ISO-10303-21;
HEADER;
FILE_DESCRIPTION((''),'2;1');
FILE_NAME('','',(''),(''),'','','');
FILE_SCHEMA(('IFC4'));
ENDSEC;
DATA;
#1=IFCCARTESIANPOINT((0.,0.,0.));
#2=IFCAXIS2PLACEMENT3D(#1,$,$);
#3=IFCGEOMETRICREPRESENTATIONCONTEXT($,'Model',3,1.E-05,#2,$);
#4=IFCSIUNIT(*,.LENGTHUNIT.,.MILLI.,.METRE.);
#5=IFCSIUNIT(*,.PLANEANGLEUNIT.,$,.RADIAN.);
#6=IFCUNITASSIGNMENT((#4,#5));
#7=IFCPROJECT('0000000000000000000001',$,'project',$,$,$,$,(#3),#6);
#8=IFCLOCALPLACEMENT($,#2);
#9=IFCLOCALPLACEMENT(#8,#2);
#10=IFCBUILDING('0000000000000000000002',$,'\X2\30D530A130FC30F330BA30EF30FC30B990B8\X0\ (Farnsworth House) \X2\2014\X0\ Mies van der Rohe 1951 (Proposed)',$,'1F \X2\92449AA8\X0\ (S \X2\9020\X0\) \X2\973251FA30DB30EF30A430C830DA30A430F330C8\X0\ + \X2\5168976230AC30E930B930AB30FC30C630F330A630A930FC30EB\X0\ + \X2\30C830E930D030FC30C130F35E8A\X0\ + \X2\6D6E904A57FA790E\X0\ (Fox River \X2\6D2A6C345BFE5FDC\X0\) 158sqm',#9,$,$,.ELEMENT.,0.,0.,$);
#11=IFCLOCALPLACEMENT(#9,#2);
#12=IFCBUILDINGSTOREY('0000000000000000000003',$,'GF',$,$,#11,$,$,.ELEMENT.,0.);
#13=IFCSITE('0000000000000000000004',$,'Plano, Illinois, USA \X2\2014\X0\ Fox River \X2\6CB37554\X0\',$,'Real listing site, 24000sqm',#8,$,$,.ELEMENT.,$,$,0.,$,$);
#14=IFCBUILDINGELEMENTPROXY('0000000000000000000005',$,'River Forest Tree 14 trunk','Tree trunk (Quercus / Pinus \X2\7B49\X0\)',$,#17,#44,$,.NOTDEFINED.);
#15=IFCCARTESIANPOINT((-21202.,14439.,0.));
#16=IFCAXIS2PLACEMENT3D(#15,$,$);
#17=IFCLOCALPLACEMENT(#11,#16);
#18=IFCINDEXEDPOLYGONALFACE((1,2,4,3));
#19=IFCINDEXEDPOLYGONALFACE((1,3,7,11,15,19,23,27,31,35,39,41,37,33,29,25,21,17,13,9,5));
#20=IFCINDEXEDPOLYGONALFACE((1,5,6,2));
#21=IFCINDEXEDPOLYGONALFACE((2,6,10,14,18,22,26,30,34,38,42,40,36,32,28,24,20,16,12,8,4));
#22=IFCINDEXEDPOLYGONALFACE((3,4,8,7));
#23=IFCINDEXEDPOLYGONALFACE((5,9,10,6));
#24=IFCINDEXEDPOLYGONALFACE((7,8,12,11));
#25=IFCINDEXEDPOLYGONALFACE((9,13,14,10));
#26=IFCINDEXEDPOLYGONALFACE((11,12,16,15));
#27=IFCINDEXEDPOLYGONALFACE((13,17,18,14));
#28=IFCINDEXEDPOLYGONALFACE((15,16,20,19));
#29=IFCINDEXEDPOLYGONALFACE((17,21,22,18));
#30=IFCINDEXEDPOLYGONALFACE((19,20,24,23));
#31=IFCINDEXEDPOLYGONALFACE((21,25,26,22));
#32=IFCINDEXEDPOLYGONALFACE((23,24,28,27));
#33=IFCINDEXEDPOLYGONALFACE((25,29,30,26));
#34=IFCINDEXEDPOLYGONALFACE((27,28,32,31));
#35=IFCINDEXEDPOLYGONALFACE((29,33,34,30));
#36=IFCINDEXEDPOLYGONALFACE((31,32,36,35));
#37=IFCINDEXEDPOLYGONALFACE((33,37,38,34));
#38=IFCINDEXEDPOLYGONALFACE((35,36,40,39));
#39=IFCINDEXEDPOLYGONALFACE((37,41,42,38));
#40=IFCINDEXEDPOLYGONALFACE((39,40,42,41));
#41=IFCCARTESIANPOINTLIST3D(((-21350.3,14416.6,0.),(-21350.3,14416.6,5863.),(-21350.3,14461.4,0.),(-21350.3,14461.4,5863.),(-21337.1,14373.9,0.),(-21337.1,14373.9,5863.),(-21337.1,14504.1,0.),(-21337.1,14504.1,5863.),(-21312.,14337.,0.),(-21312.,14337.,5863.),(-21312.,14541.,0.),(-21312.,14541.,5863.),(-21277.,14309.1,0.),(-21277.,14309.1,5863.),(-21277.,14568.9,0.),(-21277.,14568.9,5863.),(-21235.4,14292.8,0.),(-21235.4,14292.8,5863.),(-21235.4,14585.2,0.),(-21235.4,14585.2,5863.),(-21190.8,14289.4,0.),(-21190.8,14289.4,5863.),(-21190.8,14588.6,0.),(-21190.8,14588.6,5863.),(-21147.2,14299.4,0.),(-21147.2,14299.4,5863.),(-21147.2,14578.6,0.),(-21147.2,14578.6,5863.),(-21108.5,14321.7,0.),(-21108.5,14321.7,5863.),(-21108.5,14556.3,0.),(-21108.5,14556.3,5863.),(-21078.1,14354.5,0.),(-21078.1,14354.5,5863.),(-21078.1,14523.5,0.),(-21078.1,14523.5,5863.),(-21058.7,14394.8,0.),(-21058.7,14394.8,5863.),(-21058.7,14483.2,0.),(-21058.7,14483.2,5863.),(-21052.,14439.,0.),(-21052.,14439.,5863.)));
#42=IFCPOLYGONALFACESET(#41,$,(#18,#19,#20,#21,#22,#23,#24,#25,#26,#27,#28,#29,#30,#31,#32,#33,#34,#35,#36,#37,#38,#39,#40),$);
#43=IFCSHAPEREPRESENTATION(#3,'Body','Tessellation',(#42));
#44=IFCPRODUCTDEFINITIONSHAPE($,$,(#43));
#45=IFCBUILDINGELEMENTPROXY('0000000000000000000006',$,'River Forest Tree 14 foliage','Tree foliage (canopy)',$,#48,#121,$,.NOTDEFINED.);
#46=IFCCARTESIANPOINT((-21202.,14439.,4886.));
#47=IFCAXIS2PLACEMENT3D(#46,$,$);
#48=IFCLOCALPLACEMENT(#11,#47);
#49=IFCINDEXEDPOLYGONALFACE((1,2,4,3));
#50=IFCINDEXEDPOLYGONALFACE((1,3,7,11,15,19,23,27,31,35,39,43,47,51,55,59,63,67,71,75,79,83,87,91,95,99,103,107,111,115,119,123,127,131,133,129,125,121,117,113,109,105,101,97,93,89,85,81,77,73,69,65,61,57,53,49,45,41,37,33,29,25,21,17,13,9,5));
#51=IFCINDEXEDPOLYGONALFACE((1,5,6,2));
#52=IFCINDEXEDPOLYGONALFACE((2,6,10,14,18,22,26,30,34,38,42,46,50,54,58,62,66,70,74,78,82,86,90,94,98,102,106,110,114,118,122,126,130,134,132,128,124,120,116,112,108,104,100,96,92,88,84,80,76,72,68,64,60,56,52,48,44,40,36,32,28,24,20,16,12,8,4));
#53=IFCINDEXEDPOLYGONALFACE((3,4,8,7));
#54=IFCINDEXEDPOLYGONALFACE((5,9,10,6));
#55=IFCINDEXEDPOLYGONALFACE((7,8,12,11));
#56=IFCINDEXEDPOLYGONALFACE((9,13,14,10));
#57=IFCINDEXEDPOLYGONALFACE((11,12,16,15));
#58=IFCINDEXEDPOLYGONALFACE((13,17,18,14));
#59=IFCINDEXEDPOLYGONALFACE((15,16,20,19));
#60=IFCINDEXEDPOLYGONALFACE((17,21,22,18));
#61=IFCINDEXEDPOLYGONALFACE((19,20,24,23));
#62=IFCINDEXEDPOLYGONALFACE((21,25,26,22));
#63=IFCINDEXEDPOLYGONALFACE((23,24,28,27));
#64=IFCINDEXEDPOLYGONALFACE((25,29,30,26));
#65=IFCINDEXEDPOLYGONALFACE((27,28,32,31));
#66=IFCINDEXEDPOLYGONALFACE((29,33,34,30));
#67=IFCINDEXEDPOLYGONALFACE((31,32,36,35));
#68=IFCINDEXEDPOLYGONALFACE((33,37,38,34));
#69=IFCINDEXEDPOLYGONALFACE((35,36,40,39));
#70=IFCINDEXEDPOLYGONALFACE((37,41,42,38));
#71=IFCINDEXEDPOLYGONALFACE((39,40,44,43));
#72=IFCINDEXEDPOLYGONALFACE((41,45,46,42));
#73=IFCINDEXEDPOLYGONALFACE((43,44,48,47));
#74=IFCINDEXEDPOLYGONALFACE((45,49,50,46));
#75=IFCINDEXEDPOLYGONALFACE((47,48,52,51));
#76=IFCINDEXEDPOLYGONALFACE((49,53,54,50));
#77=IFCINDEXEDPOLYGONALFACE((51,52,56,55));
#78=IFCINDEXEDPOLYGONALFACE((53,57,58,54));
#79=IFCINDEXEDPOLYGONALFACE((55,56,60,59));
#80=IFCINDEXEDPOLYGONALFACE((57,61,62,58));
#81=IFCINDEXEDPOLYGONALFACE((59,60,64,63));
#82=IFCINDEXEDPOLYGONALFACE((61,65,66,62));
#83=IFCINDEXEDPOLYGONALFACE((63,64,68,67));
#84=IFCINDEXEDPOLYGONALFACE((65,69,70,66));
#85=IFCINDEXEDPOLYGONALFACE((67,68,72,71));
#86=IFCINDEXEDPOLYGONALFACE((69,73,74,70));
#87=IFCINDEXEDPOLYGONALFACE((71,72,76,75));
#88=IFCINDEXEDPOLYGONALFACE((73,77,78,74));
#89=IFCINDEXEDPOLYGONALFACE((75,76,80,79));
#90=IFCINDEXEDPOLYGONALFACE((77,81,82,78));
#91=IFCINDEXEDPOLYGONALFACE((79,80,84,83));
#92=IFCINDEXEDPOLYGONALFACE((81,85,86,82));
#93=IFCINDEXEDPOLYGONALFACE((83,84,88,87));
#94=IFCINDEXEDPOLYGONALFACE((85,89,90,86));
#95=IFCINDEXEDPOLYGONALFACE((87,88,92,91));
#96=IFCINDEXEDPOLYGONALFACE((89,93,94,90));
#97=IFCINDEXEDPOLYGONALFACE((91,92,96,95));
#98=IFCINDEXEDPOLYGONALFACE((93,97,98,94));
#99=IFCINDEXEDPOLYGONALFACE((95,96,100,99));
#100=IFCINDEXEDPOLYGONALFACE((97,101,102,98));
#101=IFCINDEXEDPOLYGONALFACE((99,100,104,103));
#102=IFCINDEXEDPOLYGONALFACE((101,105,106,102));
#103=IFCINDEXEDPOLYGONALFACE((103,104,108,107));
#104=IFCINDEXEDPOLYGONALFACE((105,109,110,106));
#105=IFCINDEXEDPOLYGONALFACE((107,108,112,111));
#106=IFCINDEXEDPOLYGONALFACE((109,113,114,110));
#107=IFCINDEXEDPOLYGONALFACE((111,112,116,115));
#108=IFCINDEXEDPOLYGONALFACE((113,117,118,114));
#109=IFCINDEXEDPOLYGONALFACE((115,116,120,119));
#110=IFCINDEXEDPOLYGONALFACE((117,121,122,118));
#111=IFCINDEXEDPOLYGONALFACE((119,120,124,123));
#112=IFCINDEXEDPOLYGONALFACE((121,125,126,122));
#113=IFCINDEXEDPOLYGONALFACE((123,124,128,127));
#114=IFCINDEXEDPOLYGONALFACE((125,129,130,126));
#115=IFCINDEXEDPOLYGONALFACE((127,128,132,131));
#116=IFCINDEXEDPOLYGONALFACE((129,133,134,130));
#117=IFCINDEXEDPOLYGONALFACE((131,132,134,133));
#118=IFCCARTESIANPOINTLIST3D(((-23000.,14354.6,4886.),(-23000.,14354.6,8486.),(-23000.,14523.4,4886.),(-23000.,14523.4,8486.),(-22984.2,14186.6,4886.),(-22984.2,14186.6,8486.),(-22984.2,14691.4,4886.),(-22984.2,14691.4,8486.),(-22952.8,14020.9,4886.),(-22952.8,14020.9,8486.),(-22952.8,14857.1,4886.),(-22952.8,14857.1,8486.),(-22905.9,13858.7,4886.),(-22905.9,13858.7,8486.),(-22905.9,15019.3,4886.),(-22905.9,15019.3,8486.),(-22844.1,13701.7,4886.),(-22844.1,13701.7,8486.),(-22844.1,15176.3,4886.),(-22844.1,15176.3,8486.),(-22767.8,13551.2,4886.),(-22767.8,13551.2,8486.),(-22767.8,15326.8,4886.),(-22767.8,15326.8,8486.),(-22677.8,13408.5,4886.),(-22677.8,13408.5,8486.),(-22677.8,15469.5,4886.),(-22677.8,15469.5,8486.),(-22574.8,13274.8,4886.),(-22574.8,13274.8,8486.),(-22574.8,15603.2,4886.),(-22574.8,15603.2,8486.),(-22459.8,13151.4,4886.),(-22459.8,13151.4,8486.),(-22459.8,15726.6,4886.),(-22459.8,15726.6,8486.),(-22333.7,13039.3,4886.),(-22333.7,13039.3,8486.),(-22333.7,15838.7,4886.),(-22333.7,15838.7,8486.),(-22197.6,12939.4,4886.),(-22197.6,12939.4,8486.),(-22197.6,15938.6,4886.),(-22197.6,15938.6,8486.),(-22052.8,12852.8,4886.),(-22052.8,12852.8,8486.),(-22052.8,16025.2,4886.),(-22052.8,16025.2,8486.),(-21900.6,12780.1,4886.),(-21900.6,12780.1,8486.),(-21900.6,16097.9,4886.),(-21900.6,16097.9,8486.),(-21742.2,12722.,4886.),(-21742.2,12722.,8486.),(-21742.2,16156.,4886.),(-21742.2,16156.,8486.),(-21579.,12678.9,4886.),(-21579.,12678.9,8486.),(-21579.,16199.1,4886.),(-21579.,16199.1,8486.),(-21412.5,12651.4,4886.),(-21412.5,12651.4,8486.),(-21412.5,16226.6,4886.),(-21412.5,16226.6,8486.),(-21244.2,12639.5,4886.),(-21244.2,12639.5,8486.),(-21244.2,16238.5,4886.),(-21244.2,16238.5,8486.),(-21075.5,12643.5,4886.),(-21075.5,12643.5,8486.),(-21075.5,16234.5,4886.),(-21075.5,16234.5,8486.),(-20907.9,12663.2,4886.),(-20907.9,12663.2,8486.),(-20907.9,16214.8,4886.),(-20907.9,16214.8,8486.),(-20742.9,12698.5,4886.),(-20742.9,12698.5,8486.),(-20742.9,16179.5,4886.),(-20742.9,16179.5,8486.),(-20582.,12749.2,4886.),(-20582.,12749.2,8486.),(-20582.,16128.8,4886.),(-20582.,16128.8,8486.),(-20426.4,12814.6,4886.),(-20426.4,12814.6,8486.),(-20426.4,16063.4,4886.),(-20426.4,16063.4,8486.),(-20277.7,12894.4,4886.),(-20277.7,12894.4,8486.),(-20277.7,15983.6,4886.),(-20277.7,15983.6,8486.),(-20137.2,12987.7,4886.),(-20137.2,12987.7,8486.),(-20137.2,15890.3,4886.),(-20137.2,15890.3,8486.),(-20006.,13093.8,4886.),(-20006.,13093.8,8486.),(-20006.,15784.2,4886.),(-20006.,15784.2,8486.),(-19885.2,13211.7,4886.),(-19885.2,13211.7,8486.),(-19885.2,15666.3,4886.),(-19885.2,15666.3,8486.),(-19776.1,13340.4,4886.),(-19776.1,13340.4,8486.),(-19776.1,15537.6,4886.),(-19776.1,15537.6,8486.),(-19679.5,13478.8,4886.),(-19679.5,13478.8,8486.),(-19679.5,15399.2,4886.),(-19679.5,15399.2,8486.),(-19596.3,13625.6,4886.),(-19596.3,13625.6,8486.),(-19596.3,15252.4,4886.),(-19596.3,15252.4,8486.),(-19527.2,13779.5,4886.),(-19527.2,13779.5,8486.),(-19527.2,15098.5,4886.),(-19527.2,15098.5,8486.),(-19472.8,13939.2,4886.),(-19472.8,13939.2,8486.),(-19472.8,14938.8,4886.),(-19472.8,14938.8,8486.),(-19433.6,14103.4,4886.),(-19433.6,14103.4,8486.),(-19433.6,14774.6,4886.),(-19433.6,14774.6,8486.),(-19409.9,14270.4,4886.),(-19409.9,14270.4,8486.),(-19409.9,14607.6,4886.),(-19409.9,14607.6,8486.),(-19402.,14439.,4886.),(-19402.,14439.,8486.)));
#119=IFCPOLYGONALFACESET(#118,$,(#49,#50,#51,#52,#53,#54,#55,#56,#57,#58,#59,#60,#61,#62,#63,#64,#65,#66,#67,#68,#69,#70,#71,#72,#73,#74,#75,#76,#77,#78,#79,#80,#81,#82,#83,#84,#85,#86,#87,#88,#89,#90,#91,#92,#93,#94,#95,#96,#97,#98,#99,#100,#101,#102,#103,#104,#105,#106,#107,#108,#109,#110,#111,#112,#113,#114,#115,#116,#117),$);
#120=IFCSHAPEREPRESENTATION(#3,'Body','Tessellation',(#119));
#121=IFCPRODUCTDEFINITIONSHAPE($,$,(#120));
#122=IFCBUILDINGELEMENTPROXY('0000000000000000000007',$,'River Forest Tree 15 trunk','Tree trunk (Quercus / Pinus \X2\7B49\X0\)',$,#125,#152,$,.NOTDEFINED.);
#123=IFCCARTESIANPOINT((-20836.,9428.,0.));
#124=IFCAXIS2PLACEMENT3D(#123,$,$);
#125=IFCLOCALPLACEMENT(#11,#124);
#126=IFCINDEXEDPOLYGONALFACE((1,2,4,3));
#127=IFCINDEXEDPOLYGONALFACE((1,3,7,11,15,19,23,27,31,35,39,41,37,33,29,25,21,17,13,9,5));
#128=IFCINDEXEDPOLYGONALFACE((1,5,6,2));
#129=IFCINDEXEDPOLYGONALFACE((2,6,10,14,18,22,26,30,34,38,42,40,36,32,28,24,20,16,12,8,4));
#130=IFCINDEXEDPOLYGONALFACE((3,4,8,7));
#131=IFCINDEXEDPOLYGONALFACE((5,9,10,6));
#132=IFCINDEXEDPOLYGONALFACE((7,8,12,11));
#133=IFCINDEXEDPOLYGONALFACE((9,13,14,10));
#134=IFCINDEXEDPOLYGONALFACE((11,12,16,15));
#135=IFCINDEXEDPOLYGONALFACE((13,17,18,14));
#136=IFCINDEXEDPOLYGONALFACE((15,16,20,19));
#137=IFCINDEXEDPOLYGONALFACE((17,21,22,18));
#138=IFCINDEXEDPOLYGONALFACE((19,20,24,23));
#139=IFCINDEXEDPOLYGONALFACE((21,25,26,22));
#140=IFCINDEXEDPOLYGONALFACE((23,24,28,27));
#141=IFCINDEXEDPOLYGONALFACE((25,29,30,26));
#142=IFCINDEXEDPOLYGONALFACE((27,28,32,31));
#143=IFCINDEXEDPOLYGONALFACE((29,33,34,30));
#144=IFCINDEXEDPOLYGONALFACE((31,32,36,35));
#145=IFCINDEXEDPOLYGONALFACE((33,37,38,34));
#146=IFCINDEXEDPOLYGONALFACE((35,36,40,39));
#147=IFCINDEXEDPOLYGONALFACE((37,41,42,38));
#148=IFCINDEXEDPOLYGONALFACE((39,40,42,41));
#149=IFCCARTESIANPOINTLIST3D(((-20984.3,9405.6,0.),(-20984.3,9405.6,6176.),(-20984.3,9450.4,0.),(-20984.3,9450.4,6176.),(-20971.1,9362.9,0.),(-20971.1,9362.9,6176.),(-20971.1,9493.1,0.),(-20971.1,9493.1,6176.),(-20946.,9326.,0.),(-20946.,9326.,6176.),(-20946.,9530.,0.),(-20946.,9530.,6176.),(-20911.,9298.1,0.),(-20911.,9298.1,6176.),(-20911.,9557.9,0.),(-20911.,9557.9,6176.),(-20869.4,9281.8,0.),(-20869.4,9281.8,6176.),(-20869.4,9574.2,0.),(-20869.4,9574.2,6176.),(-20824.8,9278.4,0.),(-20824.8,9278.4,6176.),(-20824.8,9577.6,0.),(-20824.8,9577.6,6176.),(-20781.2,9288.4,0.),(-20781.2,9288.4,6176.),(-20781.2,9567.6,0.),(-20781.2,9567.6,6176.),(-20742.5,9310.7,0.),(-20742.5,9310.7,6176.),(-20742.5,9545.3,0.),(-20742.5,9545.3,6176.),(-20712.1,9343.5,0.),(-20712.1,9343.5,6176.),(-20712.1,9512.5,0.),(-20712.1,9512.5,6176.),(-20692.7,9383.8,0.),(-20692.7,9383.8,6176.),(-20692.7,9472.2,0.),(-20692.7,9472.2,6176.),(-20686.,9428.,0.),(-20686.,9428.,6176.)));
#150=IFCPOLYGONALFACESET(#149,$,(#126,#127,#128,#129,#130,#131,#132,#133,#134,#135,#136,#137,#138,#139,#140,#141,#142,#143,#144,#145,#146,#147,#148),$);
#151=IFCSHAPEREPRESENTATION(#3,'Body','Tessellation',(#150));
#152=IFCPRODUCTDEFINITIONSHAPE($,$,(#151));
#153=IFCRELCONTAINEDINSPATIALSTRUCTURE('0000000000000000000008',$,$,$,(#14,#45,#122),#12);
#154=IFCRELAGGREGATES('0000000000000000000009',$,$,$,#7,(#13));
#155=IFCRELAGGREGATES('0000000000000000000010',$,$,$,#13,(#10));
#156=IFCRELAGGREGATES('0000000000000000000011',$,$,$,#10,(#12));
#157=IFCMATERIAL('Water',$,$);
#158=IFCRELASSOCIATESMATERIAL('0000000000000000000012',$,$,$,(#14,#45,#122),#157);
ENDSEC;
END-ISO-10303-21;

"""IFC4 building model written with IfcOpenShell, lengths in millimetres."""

from ifc_helpers import new_model, si_unit, frame, origin, origin_2d, place, context, project, spatial, circle, extrude, material, element, save


model = new_model("IFC4")

# Units and contexts
model_context = context("Model", 3, precision=1e-05, world=origin())
ifc_project = project(units=[si_unit("LENGTHUNIT", "METRE", prefix="MILLI"), si_unit("PLANEANGLEUNIT", "RADIAN")], contexts=[model_context])

# Site, building, storey
site_placement = place(None, origin())
site = spatial("IfcSite", under=ifc_project, at=site_placement, Name="Plano, Illinois, USA — Fox River 河畔", ObjectType="Real listing site, 24000sqm", CompositionType="ELEMENT", RefElevation=0.0)
building_placement = place(site_placement, origin())
building = spatial("IfcBuilding", under=site, at=building_placement, Name="ファーンズワース邸 (Farnsworth House) — Mies van der Rohe 1951 (Proposed)", ObjectType="1F 鉄骨 (S 造) 露出ホワイトペイント + 全面ガラスカーテンウォール + トラバーチン床 + 浮遊基礎 (Fox River 洪水対応) 158sqm", CompositionType="ELEMENT", ElevationOfRefHeight=0.0, ElevationOfTerrain=0.0)
storey_placement = place(building_placement, origin())
storey = spatial("IfcBuildingStorey", under=building, at=storey_placement, Name="GF", CompositionType="ELEMENT", Elevation=0.0)

# Building element proxies
ifc_material_1 = material(Name="Water")
proxy_1_placement = place(storey_placement, frame((-21202.0, 14439.0, 0.0)))
element("IfcBuildingElementProxy", 1, at=proxy_1_placement, inside=storey, material=ifc_material_1, Name="River Forest Tree 14 trunk", Description="Tree trunk (Quercus / Pinus 等)", PredefinedType="NOTDEFINED", context=model_context, shape_type="SweptSolid", body=[
    extrude(circle(Radius=150.0, at=origin_2d()), frame((-21202.0, 14439.0, 0.0)), (0.0, 0.0, 1.0), 5863.0),
])
proxy_2_placement = place(storey_placement, frame((-21202.0, 14439.0, 4886.0)))
element("IfcBuildingElementProxy", 2, at=proxy_2_placement, inside=storey, material=ifc_material_1, Name="River Forest Tree 14 foliage", Description="Tree foliage (canopy)", PredefinedType="NOTDEFINED", context=model_context, shape_type="SweptSolid", body=[
    extrude(circle(Radius=1800.0, at=origin_2d()), frame((-21202.0, 14439.0, 4886.0)), (0.0, 0.0, 1.0), 3600.0),
])
proxy_3_placement = place(storey_placement, frame((-20836.0, 9428.0, 0.0)))
element("IfcBuildingElementProxy", 3, at=proxy_3_placement, inside=storey, material=ifc_material_1, Name="River Forest Tree 15 trunk", Description="Tree trunk (Quercus / Pinus 等)", PredefinedType="NOTDEFINED", context=model_context, shape_type="SweptSolid", body=[
    extrude(circle(Radius=150.0, at=origin_2d()), frame((-20836.0, 9428.0, 0.0)), (0.0, 0.0, 1.0), 6176.0),
])

save(model, "model.ifc")
